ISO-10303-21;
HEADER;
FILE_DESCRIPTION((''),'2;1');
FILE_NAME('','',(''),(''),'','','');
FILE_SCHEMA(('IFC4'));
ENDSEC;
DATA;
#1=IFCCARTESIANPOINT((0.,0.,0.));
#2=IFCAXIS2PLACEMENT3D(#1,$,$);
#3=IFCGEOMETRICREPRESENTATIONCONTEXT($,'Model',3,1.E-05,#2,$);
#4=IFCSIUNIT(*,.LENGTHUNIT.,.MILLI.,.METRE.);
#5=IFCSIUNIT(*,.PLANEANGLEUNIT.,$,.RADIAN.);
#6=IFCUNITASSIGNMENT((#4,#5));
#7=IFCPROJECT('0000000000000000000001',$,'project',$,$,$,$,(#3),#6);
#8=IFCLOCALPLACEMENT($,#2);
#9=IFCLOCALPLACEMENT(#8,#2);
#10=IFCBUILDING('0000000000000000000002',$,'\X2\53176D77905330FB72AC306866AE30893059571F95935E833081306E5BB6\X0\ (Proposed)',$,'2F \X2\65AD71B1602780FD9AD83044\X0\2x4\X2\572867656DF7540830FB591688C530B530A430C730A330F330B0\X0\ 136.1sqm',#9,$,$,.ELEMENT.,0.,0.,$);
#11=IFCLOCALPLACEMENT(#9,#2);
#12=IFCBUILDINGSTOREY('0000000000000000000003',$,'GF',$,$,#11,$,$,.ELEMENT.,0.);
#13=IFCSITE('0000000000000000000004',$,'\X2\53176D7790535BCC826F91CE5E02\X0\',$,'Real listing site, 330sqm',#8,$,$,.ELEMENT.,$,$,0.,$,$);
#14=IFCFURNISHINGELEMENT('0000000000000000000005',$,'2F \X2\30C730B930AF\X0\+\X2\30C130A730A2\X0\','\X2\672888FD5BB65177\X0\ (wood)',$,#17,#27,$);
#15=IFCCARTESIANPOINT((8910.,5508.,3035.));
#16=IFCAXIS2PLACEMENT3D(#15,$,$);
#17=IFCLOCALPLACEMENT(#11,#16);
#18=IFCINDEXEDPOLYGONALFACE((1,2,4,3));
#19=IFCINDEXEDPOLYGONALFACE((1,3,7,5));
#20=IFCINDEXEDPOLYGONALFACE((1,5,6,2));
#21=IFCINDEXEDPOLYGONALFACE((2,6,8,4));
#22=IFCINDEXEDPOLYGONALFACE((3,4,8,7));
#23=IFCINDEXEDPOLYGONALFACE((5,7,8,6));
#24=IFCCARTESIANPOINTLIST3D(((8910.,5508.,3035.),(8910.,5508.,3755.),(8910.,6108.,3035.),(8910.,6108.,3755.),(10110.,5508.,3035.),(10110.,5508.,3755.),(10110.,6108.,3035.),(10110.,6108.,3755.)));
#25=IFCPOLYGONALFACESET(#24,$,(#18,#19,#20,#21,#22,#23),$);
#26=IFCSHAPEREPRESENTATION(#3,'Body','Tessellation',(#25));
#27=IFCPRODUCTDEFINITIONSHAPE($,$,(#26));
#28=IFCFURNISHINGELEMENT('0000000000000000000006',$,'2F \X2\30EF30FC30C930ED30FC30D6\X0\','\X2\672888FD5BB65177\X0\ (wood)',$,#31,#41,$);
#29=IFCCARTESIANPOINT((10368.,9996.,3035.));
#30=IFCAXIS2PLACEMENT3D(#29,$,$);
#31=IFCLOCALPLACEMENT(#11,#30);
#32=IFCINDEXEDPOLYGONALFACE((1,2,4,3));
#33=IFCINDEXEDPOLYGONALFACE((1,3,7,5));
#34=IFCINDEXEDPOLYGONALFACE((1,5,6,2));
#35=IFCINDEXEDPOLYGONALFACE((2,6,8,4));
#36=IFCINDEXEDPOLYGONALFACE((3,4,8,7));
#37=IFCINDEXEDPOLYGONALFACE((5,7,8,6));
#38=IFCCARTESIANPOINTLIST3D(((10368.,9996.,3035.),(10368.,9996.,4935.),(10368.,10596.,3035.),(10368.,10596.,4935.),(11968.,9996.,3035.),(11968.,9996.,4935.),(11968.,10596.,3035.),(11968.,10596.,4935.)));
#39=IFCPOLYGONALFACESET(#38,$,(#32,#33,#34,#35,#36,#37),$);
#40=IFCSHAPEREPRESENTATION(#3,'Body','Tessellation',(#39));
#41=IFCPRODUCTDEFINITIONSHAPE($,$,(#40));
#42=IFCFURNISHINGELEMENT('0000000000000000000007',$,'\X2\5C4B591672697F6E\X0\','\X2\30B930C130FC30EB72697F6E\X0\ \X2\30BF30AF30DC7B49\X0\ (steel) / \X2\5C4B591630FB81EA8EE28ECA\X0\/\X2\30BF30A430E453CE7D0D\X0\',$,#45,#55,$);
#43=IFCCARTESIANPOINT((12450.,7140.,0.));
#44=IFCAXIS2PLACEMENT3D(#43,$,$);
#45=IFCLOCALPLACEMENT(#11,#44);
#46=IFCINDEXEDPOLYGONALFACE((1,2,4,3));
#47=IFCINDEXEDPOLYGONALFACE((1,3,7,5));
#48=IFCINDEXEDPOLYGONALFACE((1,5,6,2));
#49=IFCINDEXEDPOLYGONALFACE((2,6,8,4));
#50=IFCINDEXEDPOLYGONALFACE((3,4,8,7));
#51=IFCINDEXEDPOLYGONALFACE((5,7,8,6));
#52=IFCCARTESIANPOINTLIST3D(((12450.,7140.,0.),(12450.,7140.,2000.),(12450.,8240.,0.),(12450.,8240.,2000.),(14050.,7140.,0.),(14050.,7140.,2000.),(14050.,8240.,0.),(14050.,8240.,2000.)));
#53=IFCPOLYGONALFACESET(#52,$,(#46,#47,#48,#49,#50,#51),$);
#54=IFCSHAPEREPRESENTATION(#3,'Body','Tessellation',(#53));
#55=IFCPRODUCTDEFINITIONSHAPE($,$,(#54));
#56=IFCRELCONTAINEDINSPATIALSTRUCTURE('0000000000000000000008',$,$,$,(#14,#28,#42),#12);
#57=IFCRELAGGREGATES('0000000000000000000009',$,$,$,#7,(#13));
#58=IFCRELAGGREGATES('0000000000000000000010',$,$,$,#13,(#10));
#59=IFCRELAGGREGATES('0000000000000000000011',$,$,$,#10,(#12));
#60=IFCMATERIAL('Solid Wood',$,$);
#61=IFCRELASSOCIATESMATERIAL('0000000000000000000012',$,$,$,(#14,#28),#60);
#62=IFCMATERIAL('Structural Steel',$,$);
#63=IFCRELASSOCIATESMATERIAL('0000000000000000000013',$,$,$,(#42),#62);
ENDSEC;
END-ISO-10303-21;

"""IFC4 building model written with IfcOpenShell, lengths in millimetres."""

from ifc_helpers import new_model, si_unit, frame, frame_2d, origin, place, context, project, spatial, rectangle, extrude, material, element, save


model = new_model("IFC4")

# Units and contexts
model_context = context("Model", 3, precision=1e-05, world=origin())
ifc_project = project(units=[si_unit("LENGTHUNIT", "METRE", prefix="MILLI"), si_unit("PLANEANGLEUNIT", "RADIAN")], contexts=[model_context])

# Site, building, storey
site_placement = place(None, origin())
site = spatial("IfcSite", under=ifc_project, at=site_placement, Name="北海道富良野市", ObjectType="Real listing site, 330sqm", CompositionType="ELEMENT", RefElevation=0.0)
building_placement = place(site_placement, origin())
building = spatial("IfcBuilding", under=site, at=building_placement, Name="北海道・犬と暮らす土間広めの家 (Proposed)", ObjectType="2F 断熱性能高い2x4在来混合・外装サイディング 136.1sqm", CompositionType="ELEMENT", ElevationOfRefHeight=0.0, ElevationOfTerrain=0.0)
storey_placement = place(building_placement, origin())
storey = spatial("IfcBuildingStorey", under=building, at=storey_placement, Name="GF", CompositionType="ELEMENT", Elevation=0.0)

# Shared definitions
ifc_material_1 = material(Name="Solid Wood")

# Shared definitions
ifc_material_2 = material(Name="Structural Steel")

# Furnishing elements
furnishing_1_placement = place(storey_placement, frame((8910.0, 5508.0, 3035.0)))
element("IfcFurnishingElement", 1, at=furnishing_1_placement, inside=storey, material=ifc_material_1, Name="2F デスク+チェア", Description="木製家具 (wood)", context=model_context, shape_type="SweptSolid", body=[
    extrude(rectangle(XDim=1200.0, YDim=600.0, at=frame_2d((600.0, 300.0))), frame((8910.0, 5508.0, 3035.0)), (0.0, 0.0, 1.0), 720.0),
])
furnishing_2_placement = place(storey_placement, frame((10368.0, 9996.0, 3035.0)))
element("IfcFurnishingElement", 2, at=furnishing_2_placement, inside=storey, material=ifc_material_1, Name="2F ワードローブ", Description="木製家具 (wood)", context=model_context, shape_type="SweptSolid", body=[
    extrude(rectangle(XDim=1600.0, YDim=600.0, at=frame_2d((800.0, 300.0))), frame((10368.0, 9996.0, 3035.0)), (0.0, 0.0, 1.0), 1900.0),
])
furnishing_3_placement = place(storey_placement, frame((12450.0, 7140.0, 0.0)))
element("IfcFurnishingElement", 3, at=furnishing_3_placement, inside=storey, material=ifc_material_2, Name="屋外物置", Description="スチール物置 タクボ等 (steel) / 屋外・自転車/タイヤ収納", context=model_context, shape_type="SweptSolid", body=[
    extrude(rectangle(XDim=1600.0, YDim=1100.0, at=frame_2d((800.0, 550.0))), frame((12450.0, 7140.0, 0.0)), (0.0, 0.0, 1.0), 2000.0),
])

save(model, "model.ifc")
